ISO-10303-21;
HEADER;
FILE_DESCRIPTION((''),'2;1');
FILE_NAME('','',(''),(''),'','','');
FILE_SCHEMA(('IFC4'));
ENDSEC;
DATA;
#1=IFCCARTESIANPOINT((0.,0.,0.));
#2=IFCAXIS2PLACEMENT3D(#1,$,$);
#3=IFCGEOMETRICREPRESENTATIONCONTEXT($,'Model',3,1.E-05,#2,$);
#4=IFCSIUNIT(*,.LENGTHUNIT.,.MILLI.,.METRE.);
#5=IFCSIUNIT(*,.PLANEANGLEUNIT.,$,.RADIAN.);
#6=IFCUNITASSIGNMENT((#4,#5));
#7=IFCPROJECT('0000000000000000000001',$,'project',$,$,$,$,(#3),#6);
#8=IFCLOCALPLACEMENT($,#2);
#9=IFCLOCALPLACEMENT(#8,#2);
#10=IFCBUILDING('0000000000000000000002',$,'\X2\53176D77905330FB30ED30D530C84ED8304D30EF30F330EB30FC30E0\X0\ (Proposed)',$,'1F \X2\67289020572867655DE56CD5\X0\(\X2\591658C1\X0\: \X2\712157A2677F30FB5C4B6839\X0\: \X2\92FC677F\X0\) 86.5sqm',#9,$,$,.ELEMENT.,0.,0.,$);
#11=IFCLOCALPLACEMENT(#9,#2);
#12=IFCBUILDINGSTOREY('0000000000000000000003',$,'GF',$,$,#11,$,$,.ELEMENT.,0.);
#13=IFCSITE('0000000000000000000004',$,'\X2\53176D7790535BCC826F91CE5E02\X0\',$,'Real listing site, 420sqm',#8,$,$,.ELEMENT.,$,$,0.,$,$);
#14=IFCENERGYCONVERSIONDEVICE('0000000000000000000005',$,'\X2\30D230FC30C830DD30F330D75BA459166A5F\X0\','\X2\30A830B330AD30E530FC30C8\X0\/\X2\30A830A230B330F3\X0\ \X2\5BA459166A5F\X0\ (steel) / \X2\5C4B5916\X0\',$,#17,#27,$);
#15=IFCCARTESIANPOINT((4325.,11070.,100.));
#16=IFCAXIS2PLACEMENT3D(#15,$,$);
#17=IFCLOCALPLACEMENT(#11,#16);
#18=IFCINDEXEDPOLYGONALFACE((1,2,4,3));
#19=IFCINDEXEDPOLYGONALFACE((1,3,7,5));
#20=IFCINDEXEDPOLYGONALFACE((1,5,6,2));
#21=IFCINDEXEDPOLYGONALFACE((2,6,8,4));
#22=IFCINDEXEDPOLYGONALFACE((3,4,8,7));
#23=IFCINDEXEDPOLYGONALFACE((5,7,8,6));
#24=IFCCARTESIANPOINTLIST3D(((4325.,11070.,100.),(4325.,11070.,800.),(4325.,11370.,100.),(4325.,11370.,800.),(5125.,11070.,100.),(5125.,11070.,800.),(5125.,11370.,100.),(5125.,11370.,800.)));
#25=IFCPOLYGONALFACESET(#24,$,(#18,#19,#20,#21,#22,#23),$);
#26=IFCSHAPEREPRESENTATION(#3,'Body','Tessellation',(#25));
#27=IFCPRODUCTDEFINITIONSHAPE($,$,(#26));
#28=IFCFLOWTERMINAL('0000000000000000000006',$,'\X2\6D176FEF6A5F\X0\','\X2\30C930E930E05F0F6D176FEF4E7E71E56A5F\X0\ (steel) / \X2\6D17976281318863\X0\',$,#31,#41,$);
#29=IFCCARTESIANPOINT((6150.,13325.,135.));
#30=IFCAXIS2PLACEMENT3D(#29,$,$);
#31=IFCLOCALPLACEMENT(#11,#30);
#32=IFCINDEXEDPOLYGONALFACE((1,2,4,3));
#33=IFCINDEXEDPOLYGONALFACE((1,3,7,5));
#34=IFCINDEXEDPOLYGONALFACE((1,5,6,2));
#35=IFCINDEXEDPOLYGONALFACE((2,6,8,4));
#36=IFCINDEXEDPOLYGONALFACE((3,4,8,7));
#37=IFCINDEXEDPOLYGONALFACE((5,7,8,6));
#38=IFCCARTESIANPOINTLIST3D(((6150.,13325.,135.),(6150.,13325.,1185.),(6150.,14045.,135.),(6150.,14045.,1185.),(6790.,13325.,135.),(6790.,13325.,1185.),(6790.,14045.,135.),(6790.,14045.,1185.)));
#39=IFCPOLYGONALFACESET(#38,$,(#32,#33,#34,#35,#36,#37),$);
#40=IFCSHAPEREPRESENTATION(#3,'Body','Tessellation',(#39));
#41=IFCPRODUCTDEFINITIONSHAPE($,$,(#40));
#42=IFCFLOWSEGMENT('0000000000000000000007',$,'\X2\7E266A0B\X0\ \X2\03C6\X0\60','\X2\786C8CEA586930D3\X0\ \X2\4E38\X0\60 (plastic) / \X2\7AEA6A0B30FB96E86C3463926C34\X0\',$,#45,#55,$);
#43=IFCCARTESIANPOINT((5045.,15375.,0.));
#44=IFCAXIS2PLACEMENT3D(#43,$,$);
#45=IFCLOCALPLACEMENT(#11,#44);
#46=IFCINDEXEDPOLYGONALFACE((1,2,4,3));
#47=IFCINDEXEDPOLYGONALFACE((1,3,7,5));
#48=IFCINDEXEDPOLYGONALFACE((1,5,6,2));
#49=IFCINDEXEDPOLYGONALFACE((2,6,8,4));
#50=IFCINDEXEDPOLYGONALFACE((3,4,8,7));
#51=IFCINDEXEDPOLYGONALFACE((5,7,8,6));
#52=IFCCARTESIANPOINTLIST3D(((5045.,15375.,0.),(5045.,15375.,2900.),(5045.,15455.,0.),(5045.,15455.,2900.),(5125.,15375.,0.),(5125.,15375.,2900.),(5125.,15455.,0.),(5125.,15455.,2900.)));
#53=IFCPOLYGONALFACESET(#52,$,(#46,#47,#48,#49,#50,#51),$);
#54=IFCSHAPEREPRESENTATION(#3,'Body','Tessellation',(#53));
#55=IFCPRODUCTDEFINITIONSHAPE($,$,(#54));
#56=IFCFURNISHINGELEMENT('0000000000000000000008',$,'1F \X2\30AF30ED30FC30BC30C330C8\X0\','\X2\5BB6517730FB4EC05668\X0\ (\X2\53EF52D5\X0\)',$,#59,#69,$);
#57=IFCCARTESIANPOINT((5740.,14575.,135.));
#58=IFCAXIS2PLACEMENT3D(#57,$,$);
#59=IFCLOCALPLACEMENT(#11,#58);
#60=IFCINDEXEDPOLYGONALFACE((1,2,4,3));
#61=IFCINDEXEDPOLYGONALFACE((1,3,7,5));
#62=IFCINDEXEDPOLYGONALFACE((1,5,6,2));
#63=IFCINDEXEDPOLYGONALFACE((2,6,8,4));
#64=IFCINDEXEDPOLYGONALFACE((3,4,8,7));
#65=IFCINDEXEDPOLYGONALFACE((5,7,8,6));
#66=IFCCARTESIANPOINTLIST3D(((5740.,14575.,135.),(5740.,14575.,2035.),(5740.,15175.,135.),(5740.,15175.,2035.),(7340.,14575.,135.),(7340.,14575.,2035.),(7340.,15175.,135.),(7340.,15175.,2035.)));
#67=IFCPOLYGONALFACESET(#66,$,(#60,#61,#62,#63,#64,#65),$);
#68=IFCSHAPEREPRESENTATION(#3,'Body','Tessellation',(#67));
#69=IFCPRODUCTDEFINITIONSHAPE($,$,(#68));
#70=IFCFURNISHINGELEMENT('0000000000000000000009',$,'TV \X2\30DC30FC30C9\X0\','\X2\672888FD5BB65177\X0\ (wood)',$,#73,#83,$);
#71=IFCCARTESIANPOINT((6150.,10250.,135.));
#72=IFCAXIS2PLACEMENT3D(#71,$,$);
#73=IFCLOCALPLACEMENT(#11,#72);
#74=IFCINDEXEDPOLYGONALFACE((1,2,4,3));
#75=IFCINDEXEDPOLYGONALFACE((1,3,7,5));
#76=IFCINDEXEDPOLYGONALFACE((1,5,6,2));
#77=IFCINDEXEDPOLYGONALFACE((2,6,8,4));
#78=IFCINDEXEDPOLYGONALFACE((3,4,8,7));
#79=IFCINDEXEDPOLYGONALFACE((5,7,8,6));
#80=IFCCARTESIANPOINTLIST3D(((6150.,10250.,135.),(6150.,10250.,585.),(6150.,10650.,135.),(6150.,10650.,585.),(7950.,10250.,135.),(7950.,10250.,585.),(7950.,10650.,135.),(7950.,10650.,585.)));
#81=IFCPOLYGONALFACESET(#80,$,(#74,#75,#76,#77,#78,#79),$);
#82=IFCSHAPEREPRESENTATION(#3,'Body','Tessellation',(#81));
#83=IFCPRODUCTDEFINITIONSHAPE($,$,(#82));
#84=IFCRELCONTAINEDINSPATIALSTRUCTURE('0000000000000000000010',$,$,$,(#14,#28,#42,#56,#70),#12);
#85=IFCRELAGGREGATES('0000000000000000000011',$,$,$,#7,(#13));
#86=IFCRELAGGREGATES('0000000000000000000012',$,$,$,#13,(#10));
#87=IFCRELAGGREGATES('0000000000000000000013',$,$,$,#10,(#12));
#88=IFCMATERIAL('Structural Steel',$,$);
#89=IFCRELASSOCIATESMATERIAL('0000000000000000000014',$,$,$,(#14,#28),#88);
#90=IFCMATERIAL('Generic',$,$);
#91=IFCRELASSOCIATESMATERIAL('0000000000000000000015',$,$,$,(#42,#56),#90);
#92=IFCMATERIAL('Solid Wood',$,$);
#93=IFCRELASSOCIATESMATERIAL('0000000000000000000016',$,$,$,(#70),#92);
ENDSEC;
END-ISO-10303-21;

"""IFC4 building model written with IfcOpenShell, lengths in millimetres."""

from ifc_helpers import new_model, si_unit, frame, frame_2d, origin, place, context, project, spatial, rectangle, extrude, material, element, save


model = new_model("IFC4")

# Units and contexts
model_context = context("Model", 3, precision=1e-05, world=origin())
ifc_project = project(units=[si_unit("LENGTHUNIT", "METRE", prefix="MILLI"), si_unit("PLANEANGLEUNIT", "RADIAN")], contexts=[model_context])

# Site, building, storey
site_placement = place(None, origin())
site = spatial("IfcSite", under=ifc_project, at=site_placement, Name="北海道富良野市", ObjectType="Real listing site, 420sqm", CompositionType="ELEMENT", RefElevation=0.0)
building_placement = place(site_placement, origin())
building = spatial("IfcBuilding", under=site, at=building_placement, Name="北海道・ロフト付きワンルーム (Proposed)", ObjectType="1F 木造在来工法(外壁: 無垢板・屋根: 鋼板) 86.5sqm", CompositionType="ELEMENT", ElevationOfRefHeight=0.0, ElevationOfTerrain=0.0)
storey_placement = place(building_placement, origin())
storey = spatial("IfcBuildingStorey", under=building, at=storey_placement, Name="GF", CompositionType="ELEMENT", Elevation=0.0)

# Shared definitions
ifc_material_1 = material(Name="Solid Wood")

# Shared definitions
ifc_material_2 = material(Name="Structural Steel")

# Shared definitions
ifc_material_3 = material(Name="Generic")

# Energy conversion device
energy_conversion_device_placement = place(storey_placement, frame((4325.0, 11070.0, 100.0)))
element("IfcEnergyConversionDevice", 1, at=energy_conversion_device_placement, inside=storey, material=ifc_material_2, Name="ヒートポンプ室外機", Description="エコキュート/エアコン 室外機 (steel) / 屋外", context=model_context, shape_type="SweptSolid", body=[
    extrude(rectangle(XDim=800.0, YDim=300.0, at=frame_2d((400.0, 150.0))), frame((4325.0, 11070.0, 100.0)), (0.0, 0.0, 1.0), 700.0),
])

# Flow terminal
flow_terminal_placement = place(storey_placement, frame((6150.0, 13325.0, 135.0)))
element("IfcFlowTerminal", 2, at=flow_terminal_placement, inside=storey, material=ifc_material_2, Name="洗濯機", Description="ドラム式洗濯乾燥機 (steel) / 洗面脱衣", context=model_context, shape_type="SweptSolid", body=[
    extrude(rectangle(XDim=640.0, YDim=720.0, at=frame_2d((320.0, 360.0))), frame((6150.0, 13325.0, 135.0)), (0.0, 0.0, 1.0), 1050.0),
])

# Flow segment
flow_segment_1_placement = place(storey_placement, frame((5045.0, 15375.0, 0.0)))
element("IfcFlowSegment", 3, at=flow_segment_1_placement, inside=storey, material=ifc_material_3, Name="縦樋 φ60", Description="硬質塩ビ 丸60 (plastic) / 竪樋・雨水排水", context=model_context, shape_type="SweptSolid", body=[
    extrude(rectangle(XDim=80.0, YDim=80.0, at=frame_2d((40.0, 40.0))), frame((5045.0, 15375.0, 0.0)), (0.0, 0.0, 1.0), 2900.0),
])

# Furnishing elements
furnishing_1_placement = place(storey_placement, frame((5740.0, 14575.0, 135.0)))
element("IfcFurnishingElement", 4, at=furnishing_1_placement, inside=storey, material=ifc_material_3, Name="1F クローゼット", Description="家具・什器 (可動)", context=model_context, shape_type="SweptSolid", body=[
    extrude(rectangle(XDim=1600.0, YDim=600.0, at=frame_2d((800.0, 300.0))), frame((5740.0, 14575.0, 135.0)), (0.0, 0.0, 1.0), 1900.0),
])
furnishing_2_placement = place(storey_placement, frame((6150.0, 10250.0, 135.0)))
element("IfcFurnishingElement", 5, at=furnishing_2_placement, inside=storey, material=ifc_material_1, Name="TV ボード", Description="木製家具 (wood)", context=model_context, shape_type="SweptSolid", body=[
    extrude(rectangle(XDim=1800.0, YDim=400.0, at=frame_2d((900.0, 200.0))), frame((6150.0, 10250.0, 135.0)), (0.0, 0.0, 1.0), 450.0),
])

save(model, "model.ifc")
